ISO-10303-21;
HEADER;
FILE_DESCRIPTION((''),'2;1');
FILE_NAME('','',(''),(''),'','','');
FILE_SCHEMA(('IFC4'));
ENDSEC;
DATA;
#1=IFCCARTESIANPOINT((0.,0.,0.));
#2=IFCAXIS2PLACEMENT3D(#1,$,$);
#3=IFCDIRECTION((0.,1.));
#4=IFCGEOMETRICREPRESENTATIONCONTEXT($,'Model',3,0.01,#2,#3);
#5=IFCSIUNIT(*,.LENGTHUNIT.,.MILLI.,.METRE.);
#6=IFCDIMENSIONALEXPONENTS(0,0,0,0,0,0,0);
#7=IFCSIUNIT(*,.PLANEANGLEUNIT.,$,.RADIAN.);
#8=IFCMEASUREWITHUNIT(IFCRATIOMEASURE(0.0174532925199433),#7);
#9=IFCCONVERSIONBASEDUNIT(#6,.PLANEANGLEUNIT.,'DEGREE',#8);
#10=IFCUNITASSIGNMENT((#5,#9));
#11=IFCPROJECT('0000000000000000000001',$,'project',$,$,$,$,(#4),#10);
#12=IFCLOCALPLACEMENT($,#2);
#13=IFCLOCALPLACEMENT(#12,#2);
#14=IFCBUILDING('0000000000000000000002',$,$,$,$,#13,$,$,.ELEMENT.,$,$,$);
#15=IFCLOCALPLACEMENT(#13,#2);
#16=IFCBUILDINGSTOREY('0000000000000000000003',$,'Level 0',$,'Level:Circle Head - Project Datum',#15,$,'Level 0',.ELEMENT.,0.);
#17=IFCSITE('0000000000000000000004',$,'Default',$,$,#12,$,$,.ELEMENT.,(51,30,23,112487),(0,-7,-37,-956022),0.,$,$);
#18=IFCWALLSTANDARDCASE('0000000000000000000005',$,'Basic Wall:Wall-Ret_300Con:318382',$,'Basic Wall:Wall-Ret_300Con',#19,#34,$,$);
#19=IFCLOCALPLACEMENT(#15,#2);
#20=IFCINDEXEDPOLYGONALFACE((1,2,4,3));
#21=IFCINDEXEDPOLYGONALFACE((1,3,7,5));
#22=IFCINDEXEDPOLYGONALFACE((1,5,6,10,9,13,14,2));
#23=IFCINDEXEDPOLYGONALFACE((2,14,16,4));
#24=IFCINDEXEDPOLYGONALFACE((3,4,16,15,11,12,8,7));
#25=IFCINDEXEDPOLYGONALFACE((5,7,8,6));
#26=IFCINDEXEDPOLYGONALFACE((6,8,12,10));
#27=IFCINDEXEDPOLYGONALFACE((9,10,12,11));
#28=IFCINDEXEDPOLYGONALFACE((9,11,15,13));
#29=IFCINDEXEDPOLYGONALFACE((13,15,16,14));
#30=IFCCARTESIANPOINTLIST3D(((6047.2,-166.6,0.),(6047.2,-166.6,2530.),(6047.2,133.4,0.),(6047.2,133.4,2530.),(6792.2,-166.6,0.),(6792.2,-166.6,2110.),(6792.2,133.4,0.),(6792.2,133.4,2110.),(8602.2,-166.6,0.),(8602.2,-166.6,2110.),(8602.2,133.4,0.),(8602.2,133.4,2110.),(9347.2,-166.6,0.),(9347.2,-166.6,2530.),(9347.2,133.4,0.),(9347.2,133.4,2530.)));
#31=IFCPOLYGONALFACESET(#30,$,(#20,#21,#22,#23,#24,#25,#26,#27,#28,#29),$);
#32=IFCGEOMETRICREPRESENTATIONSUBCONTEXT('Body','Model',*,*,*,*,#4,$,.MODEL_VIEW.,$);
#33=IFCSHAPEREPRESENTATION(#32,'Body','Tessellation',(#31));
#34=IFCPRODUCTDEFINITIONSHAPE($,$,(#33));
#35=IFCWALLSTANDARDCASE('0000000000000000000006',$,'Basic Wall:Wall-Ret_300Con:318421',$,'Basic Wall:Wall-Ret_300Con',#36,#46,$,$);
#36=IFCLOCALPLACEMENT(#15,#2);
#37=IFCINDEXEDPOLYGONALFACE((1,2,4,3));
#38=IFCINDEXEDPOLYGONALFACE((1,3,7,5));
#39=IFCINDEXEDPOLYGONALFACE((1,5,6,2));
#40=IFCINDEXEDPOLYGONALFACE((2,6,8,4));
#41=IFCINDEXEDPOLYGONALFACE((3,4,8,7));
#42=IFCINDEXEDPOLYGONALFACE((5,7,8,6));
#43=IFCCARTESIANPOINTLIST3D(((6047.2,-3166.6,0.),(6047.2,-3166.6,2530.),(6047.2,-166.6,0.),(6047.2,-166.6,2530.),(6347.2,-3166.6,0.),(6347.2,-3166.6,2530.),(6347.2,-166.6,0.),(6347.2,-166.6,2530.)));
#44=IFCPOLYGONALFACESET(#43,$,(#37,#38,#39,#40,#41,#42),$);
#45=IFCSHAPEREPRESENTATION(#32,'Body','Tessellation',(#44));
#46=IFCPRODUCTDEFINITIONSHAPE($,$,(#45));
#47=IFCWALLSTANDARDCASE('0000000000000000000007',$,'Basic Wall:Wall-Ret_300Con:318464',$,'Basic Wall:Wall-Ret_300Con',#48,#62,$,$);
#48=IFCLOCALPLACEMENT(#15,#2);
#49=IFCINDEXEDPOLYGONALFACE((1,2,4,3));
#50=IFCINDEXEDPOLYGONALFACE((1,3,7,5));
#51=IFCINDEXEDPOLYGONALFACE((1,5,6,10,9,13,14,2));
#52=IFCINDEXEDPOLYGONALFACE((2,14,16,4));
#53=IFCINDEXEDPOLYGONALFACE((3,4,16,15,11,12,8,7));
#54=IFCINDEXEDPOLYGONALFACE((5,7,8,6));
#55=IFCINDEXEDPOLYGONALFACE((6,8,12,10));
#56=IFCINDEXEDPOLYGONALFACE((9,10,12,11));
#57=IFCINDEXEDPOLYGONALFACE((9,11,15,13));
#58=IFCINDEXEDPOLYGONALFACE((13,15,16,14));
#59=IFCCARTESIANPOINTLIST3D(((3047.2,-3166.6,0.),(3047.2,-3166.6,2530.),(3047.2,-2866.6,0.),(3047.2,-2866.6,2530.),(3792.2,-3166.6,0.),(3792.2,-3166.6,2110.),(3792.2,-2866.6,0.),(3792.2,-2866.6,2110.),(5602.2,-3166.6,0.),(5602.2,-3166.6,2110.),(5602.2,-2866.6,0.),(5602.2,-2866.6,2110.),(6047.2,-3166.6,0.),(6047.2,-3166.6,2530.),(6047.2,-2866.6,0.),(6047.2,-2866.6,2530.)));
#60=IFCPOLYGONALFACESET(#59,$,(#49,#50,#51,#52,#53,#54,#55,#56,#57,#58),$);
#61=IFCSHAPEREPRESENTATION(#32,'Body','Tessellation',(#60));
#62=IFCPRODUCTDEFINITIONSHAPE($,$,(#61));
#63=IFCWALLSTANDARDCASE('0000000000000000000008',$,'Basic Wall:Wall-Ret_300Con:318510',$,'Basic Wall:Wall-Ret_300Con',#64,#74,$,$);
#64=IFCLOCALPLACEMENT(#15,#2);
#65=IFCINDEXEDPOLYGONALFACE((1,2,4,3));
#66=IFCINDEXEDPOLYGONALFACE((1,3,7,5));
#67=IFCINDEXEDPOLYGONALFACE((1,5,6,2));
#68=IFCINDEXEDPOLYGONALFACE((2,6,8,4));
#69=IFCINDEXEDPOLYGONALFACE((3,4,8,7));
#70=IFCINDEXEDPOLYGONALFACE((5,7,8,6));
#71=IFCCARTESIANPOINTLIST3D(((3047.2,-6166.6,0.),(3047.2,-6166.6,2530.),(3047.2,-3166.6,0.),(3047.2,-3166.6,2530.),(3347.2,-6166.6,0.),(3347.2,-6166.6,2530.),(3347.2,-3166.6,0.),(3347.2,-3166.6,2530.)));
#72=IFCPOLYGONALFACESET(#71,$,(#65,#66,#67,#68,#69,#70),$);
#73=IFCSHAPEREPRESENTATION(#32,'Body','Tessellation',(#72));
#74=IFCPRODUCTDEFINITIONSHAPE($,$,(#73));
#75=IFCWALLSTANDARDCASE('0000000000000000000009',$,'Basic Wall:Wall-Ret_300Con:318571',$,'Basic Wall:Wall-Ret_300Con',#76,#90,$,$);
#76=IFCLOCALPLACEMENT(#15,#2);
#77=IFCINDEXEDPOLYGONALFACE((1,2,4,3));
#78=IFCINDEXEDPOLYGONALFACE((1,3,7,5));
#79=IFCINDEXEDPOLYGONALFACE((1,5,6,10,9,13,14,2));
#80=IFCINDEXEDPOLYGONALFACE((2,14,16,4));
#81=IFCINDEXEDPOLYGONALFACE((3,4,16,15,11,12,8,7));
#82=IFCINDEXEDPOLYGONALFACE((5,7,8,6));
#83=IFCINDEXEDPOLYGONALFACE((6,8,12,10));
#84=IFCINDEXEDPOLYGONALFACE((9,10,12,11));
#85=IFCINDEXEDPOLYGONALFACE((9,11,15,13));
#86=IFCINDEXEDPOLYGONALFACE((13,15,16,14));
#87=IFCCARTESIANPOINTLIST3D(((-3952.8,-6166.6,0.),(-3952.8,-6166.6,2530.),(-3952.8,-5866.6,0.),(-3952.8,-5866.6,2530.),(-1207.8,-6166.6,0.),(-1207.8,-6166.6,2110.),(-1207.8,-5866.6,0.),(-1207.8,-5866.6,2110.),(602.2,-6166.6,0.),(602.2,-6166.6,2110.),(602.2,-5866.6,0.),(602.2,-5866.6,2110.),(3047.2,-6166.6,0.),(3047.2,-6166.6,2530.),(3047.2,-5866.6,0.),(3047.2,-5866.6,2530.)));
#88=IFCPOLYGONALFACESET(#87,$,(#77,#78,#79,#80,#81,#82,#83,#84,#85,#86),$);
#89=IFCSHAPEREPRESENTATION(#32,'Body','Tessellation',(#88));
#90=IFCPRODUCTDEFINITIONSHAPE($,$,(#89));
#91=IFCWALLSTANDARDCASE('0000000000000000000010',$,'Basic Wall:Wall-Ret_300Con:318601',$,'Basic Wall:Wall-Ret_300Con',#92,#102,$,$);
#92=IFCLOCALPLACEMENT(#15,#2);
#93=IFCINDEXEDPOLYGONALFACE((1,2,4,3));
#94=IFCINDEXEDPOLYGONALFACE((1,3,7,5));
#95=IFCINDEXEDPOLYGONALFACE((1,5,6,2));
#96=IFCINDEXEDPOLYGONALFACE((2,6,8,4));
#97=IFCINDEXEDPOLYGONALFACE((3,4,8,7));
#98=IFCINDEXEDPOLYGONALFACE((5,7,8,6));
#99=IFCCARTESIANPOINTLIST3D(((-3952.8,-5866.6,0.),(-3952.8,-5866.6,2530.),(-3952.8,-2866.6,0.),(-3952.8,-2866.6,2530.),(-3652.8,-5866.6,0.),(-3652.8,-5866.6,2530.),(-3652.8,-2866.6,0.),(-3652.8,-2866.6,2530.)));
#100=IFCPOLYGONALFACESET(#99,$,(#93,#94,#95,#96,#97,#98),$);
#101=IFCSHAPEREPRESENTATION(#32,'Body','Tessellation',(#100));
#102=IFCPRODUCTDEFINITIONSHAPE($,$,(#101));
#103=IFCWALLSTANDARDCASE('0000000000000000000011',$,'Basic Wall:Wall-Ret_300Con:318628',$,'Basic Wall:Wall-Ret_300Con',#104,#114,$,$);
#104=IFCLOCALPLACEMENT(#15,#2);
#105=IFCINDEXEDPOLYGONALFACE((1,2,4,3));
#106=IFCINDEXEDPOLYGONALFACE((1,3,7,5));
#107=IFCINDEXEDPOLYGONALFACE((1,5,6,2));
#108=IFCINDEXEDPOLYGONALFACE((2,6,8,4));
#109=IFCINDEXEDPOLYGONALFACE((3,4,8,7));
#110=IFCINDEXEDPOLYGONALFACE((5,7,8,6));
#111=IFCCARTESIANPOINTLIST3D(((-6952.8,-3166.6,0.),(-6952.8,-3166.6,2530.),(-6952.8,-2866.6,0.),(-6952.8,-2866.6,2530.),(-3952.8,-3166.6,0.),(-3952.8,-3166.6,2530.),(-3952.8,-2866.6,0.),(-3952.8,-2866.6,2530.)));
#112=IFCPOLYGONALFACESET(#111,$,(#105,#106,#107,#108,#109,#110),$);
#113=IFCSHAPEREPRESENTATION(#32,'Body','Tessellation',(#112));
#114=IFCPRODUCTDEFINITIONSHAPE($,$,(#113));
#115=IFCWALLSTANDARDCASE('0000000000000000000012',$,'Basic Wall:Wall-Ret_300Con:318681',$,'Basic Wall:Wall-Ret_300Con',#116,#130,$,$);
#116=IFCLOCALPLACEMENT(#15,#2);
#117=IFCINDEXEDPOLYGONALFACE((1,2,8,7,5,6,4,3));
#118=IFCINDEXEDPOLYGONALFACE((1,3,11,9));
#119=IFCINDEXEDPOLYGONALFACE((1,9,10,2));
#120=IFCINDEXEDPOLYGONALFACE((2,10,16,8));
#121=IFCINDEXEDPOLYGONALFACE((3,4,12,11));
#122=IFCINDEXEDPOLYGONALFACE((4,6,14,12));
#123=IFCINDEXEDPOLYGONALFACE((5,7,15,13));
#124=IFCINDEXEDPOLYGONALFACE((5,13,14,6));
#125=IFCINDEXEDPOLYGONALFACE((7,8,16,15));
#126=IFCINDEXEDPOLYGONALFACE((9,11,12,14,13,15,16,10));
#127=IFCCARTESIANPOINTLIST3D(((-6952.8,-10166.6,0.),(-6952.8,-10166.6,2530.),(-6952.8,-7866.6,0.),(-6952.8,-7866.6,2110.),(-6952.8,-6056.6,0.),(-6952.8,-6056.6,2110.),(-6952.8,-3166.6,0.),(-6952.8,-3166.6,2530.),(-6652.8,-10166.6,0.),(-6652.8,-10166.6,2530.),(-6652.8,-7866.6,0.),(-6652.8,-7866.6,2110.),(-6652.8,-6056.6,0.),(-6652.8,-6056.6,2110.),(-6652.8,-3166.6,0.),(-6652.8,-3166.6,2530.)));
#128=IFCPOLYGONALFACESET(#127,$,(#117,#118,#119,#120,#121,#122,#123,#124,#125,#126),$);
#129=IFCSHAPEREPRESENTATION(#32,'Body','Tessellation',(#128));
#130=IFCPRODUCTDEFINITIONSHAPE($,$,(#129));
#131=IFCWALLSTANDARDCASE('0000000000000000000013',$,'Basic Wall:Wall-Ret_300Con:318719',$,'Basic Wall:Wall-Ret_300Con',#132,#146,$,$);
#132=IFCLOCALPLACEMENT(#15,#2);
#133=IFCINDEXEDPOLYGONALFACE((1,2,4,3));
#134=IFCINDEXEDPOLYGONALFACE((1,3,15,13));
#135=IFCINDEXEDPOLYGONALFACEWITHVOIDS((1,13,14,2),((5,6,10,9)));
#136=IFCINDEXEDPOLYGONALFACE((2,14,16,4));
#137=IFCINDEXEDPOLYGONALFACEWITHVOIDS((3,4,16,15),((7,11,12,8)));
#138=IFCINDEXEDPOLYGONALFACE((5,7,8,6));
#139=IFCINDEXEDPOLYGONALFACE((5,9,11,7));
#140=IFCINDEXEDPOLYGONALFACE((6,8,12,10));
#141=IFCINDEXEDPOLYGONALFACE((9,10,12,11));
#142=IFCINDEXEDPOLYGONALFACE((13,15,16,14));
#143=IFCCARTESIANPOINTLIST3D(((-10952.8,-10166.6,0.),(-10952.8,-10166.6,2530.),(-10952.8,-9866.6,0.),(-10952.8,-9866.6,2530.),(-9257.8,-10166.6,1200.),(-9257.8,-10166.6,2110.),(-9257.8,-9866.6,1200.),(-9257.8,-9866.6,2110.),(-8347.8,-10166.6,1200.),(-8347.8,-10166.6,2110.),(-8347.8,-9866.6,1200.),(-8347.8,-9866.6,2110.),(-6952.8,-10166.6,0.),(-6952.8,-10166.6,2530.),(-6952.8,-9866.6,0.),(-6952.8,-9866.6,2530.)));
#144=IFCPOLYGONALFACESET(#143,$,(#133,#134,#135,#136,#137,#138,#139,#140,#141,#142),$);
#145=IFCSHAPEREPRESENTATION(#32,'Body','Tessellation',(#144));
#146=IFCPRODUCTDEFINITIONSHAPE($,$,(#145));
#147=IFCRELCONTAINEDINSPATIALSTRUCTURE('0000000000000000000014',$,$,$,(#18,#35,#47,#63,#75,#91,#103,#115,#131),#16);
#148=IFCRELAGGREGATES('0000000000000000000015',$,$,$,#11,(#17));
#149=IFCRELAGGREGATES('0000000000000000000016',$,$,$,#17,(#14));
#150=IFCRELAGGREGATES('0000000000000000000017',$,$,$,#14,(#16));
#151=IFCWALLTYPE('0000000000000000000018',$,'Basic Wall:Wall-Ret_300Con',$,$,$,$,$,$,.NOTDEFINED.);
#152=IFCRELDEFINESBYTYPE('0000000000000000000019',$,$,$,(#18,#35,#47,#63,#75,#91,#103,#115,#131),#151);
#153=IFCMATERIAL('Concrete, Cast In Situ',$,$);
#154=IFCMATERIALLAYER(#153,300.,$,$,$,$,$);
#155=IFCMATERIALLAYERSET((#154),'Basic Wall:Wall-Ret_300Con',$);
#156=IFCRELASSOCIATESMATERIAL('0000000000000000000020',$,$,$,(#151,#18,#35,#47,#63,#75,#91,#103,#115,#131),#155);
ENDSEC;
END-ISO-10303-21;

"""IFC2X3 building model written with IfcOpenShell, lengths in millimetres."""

from ifc_helpers import new_model, entity, si_unit, converted_unit, direction, frame, frame_2d, origin, place, context, subcontext, project, spatial, polyline, rectangle, extrude, clip, bounded_halfspace, material, layer, layer_set, layer_usage, type_object, element, save


model = new_model("IFC2X3")

# Units and contexts
model_context = context("Model", 3, precision=0.01, world=origin(), true_north=direction((0.0, 1.0)))
body_context = subcontext(model_context, "Body", "Model", "MODEL_VIEW")
ifc_project = project(units=[si_unit("LENGTHUNIT", "METRE", prefix="MILLI"), converted_unit("PLANEANGLEUNIT", "DEGREE", entity("IfcRatioMeasure", 0.0174532925199433), si_unit("PLANEANGLEUNIT", "RADIAN"), dimensions=[0, 0, 0, 0, 0, 0, 0])], contexts=[model_context])

# Site, building, storey
site_placement = place(None, origin())
site = spatial("IfcSite", under=ifc_project, at=site_placement, Name="Default", CompositionType="ELEMENT", RefLatitude=(51, 30, 23, 112487), RefLongitude=(0, -7, -37, -956022), RefElevation=0.0)
building_placement = place(site_placement, origin())
building = spatial("IfcBuilding", under=site, at=building_placement, CompositionType="ELEMENT")
storey_placement = place(building_placement, origin())
storey = spatial("IfcBuildingStorey", under=building, at=storey_placement, Name="Level 0", ObjectType="Level:Circle Head - Project Datum", LongName="Level 0", CompositionType="ELEMENT", Elevation=0.0)

# Wall, opening
ifc_material_1 = material(Name="Concrete, Cast In Situ")
ifc_layer_1 = layer(ifc_material_1, 300.0)
ifc_layer_set_1 = layer_set([ifc_layer_1], Name="Basic Wall:Wall-Ret_300Con")
ifc_layer_usage_1 = layer_usage(ifc_layer_set_1, "AXIS2", "NEGATIVE", 150.0)
wall_type = type_object("IfcWallType", Name="Basic Wall:Wall-Ret_300Con", PredefinedType="NOTDEFINED", material=ifc_layer_set_1)
wall_1_placement = place(storey_placement, frame((9347.2, -16.6, 0.0), z_axis=(0.0, 0.0, 1.0), x_axis=(-1.0, 0.0, 0.0)))
wall_1 = element("IfcWallStandardCase", 1, at=wall_1_placement, inside=storey, type_object=wall_type, material=ifc_layer_usage_1, Name="Basic Wall:Wall-Ret_300Con:318382", ObjectType="Basic Wall:Wall-Ret_300Con", context=body_context, shape_type="Clipping", body=[
    clip(extrude(rectangle(XDim=3300.0, YDim=300.0, at=frame_2d((1650.0, 0.0), x_axis=(-1.0, 0.0))), origin(), (0.0, 0.0, 1.0), 2530.0), bounded_halfspace(frame((0.0, -150.0, 2530.0), z_axis=(0.0, 0.0, -1.0), x_axis=(-1.0, 0.0, 0.0)), True, frame((0.0, -150.0, 2530.0)), polyline([(0.0, 0.0), (300.0, 0.0), (3300.0, 0.0), (3300.0, 300.0), (3000.0, 300.0), (0.0, 300.0), (0.0, 0.0)]))),
])
opening_1_placement = place(wall_1_placement, frame((2555.0, 150.0, 0.0)))
element("IfcOpeningElement", 2, at=opening_1_placement, cuts=wall_1, ObjectType="Opening", context=body_context, shape_type="SweptSolid", body=[
    extrude(rectangle(XDim=2110.0, YDim=1810.0, at=frame_2d((1055.0, 905.0), x_axis=(-1.0, 0.0))), frame((0.0, 0.0, 0.0), z_axis=(0.0, -1.0, 0.0), x_axis=(0.0, 0.0, 1.0)), (0.0, 0.0, 1.0), 300.0),
])

# Wall
ifc_layer_usage_2 = layer_usage(ifc_layer_set_1, "AXIS2", "NEGATIVE", 150.0)
wall_2_placement = place(storey_placement, frame((6197.2, -166.6, 0.0), z_axis=(0.0, 0.0, 1.0), x_axis=(0.0, -1.0, 0.0)))
element("IfcWallStandardCase", 3, at=wall_2_placement, inside=storey, type_object=wall_type, material=ifc_layer_usage_2, Name="Basic Wall:Wall-Ret_300Con:318421", ObjectType="Basic Wall:Wall-Ret_300Con", context=body_context, shape_type="Clipping", body=[
    clip(extrude(rectangle(XDim=3000.0, YDim=300.0, at=frame_2d((1500.0, 0.0), x_axis=(-1.0, 0.0))), origin(), (0.0, 0.0, 1.0), 2530.0), bounded_halfspace(frame((0.0, -150.0, 2530.0), z_axis=(0.0, 0.0, -1.0), x_axis=(0.0, 1.0, 0.0)), True, frame((0.0, -150.0, 2530.0)), polyline([(0.0, 0.0), (2700.0, 0.0), (3000.0, 0.0), (3000.0, 300.0), (0.0, 300.0), (0.0, 0.0)]))),
])

# Wall, opening
ifc_layer_usage_3 = layer_usage(ifc_layer_set_1, "AXIS2", "NEGATIVE", 150.0)
wall_3_placement = place(storey_placement, frame((6047.2, -3016.6, 0.0), z_axis=(0.0, 0.0, 1.0), x_axis=(-1.0, 0.0, 0.0)))
wall_3 = element("IfcWallStandardCase", 4, at=wall_3_placement, inside=storey, type_object=wall_type, material=ifc_layer_usage_3, Name="Basic Wall:Wall-Ret_300Con:318464", ObjectType="Basic Wall:Wall-Ret_300Con", context=body_context, shape_type="Clipping", body=[
    clip(extrude(rectangle(XDim=3000.0, YDim=300.0, at=frame_2d((1500.0, 0.0), x_axis=(-1.0, 0.0))), origin(), (0.0, 0.0, 1.0), 2530.0), bounded_halfspace(frame((0.0, -150.0, 2530.0), z_axis=(0.0, 0.0, -1.0), x_axis=(-1.0, 0.0, 0.0)), True, frame((0.0, -150.0, 2530.0)), polyline([(0.0, 0.0), (3000.0, 0.0), (3000.0, 300.0), (2700.0, 300.0), (0.0, 300.0), (0.0, 0.0)]))),
])
opening_2_placement = place(wall_3_placement, frame((2255.0, 150.0, 0.0)))
element("IfcOpeningElement", 5, at=opening_2_placement, cuts=wall_3, ObjectType="Opening", context=body_context, shape_type="SweptSolid", body=[
    extrude(rectangle(XDim=2110.0, YDim=1810.0, at=frame_2d((1055.0, 905.0), x_axis=(-1.0, 0.0))), frame((0.0, 0.0, 0.0), z_axis=(0.0, -1.0, 0.0), x_axis=(0.0, 0.0, 1.0)), (0.0, 0.0, 1.0), 300.0),
])

# Wall
ifc_layer_usage_4 = layer_usage(ifc_layer_set_1, "AXIS2", "NEGATIVE", 150.0)
wall_4_placement = place(storey_placement, frame((3197.2, -3166.6, 0.0), z_axis=(0.0, 0.0, 1.0), x_axis=(0.0, -1.0, 0.0)))
element("IfcWallStandardCase", 6, at=wall_4_placement, inside=storey, type_object=wall_type, material=ifc_layer_usage_4, Name="Basic Wall:Wall-Ret_300Con:318510", ObjectType="Basic Wall:Wall-Ret_300Con", context=body_context, shape_type="Clipping", body=[
    clip(extrude(rectangle(XDim=3000.0, YDim=300.0, at=frame_2d((1500.0, 0.0), x_axis=(-1.0, 0.0))), origin(), (0.0, 0.0, 1.0), 2530.0), bounded_halfspace(frame((0.0, -150.0, 2530.0), z_axis=(0.0, 0.0, -1.0), x_axis=(0.0, 1.0, 0.0)), True, frame((0.0, -150.0, 2530.0)), polyline([(0.0, 0.0), (2700.0, 0.0), (3000.0, 0.0), (3000.0, 300.0), (0.0, 300.0), (0.0, 0.0)]))),
])

# Wall, opening
ifc_layer_usage_5 = layer_usage(ifc_layer_set_1, "AXIS2", "NEGATIVE", 150.0)
wall_5_placement = place(storey_placement, frame((3047.2, -6016.6, 0.0), z_axis=(0.0, 0.0, 1.0), x_axis=(-1.0, 0.0, 0.0)))
wall_5 = element("IfcWallStandardCase", 7, at=wall_5_placement, inside=storey, type_object=wall_type, material=ifc_layer_usage_5, Name="Basic Wall:Wall-Ret_300Con:318571", ObjectType="Basic Wall:Wall-Ret_300Con", context=body_context, shape_type="Clipping", body=[
    clip(extrude(rectangle(XDim=7000.0, YDim=300.0, at=frame_2d((3500.0, 0.0), x_axis=(-1.0, 0.0))), origin(), (0.0, 0.0, 1.0), 2530.0), bounded_halfspace(frame((0.0, -150.0, 2530.0), z_axis=(0.0, 0.0, -1.0), x_axis=(-1.0, 0.0, 0.0)), True, frame((0.0, -150.0, 2530.0)), polyline([(0.0, 0.0), (6700.0, 0.0), (7000.0, 0.0), (7000.0, 300.0), (0.0, 300.0), (0.0, 0.0)]))),
])
opening_3_placement = place(wall_5_placement, frame((4255.0, 150.0, 0.0)))
element("IfcOpeningElement", 8, at=opening_3_placement, cuts=wall_5, ObjectType="Opening", context=body_context, shape_type="SweptSolid", body=[
    extrude(rectangle(XDim=2110.0, YDim=1810.0, at=frame_2d((1055.0, 905.0), x_axis=(-1.0, 0.0))), frame((0.0, 0.0, 0.0), z_axis=(0.0, -1.0, 0.0), x_axis=(0.0, 0.0, 1.0)), (0.0, 0.0, 1.0), 300.0),
])

# Walls
ifc_layer_usage_6 = layer_usage(ifc_layer_set_1, "AXIS2", "NEGATIVE", 150.0)
wall_6_placement = place(storey_placement, frame((-3802.8, -5866.6, 0.0), z_axis=(0.0, 0.0, 1.0), x_axis=(0.0, 1.0, 0.0)))
element("IfcWallStandardCase", 9, at=wall_6_placement, inside=storey, type_object=wall_type, material=ifc_layer_usage_6, Name="Basic Wall:Wall-Ret_300Con:318601", ObjectType="Basic Wall:Wall-Ret_300Con", context=body_context, shape_type="Clipping", body=[
    clip(extrude(rectangle(XDim=3000.0, YDim=300.0, at=frame_2d((1500.0, 0.0), x_axis=(-1.0, 0.0))), origin(), (0.0, 0.0, 1.0), 2530.0), bounded_halfspace(frame((0.0, -150.0, 2530.0), z_axis=(0.0, 0.0, -1.0), x_axis=(0.0, -1.0, 0.0)), True, frame((0.0, -150.0, 2530.0)), polyline([(0.0, 0.0), (3000.0, 0.0), (3000.0, 300.0), (2700.0, 300.0), (0.0, 300.0), (0.0, 0.0)]))),
])
ifc_layer_usage_7 = layer_usage(ifc_layer_set_1, "AXIS2", "NEGATIVE", 150.0)
wall_7_placement = place(storey_placement, frame((-3952.8, -3016.6, 0.0), z_axis=(0.0, 0.0, 1.0), x_axis=(-1.0, 0.0, 0.0)))
element("IfcWallStandardCase", 10, at=wall_7_placement, inside=storey, type_object=wall_type, material=ifc_layer_usage_7, Name="Basic Wall:Wall-Ret_300Con:318628", ObjectType="Basic Wall:Wall-Ret_300Con", context=body_context, shape_type="Clipping", body=[
    clip(extrude(rectangle(XDim=3000.0, YDim=300.0, at=frame_2d((1500.0, 0.0), x_axis=(-1.0, 0.0))), origin(), (0.0, 0.0, 1.0), 2530.0), bounded_halfspace(frame((0.0, -150.0, 2530.0), z_axis=(0.0, 0.0, -1.0), x_axis=(-1.0, 0.0, 0.0)), True, frame((0.0, -150.0, 2530.0)), polyline([(0.0, 0.0), (3000.0, 0.0), (3000.0, 300.0), (2700.0, 300.0), (0.0, 300.0), (0.0, 0.0)]))),
])

# Walls, openings
ifc_layer_usage_8 = layer_usage(ifc_layer_set_1, "AXIS2", "NEGATIVE", 150.0)
wall_8_placement = place(storey_placement, frame((-6802.8, -3166.6, 0.0), z_axis=(0.0, 0.0, 1.0), x_axis=(0.0, -1.0, 0.0)))
wall_8 = element("IfcWallStandardCase", 11, at=wall_8_placement, inside=storey, type_object=wall_type, material=ifc_layer_usage_8, Name="Basic Wall:Wall-Ret_300Con:318681", ObjectType="Basic Wall:Wall-Ret_300Con", context=body_context, shape_type="Clipping", body=[
    clip(extrude(rectangle(XDim=7000.0, YDim=300.0, at=frame_2d((3500.0, 0.0), x_axis=(-1.0, 0.0))), origin(), (0.0, 0.0, 1.0), 2530.0), bounded_halfspace(frame((0.0, -150.0, 2530.0), z_axis=(0.0, 0.0, -1.0), x_axis=(0.0, 1.0, 0.0)), True, frame((0.0, -150.0, 2530.0)), polyline([(0.0, 0.0), (6700.0, 0.0), (7000.0, 0.0), (7000.0, 300.0), (0.0, 300.0), (0.0, 0.0)]))),
])
opening_4_placement = place(wall_8_placement, frame((4700.0, 150.0, 0.0)))
element("IfcOpeningElement", 12, at=opening_4_placement, cuts=wall_8, ObjectType="Opening", context=body_context, shape_type="SweptSolid", body=[
    extrude(rectangle(XDim=2110.0, YDim=1810.0, at=frame_2d((1055.0, 905.0), x_axis=(-1.0, 0.0))), frame((0.0, 0.0, 0.0), z_axis=(0.0, -1.0, 0.0), x_axis=(0.0, 0.0, 1.0)), (0.0, 0.0, 1.0), 300.0),
])
ifc_layer_usage_9 = layer_usage(ifc_layer_set_1, "AXIS2", "NEGATIVE", 150.0)
wall_9_placement = place(storey_placement, frame((-6952.8, -10016.6, 0.0), z_axis=(0.0, 0.0, 1.0), x_axis=(-1.0, 0.0, 0.0)))
wall_9 = element("IfcWallStandardCase", 13, at=wall_9_placement, inside=storey, type_object=wall_type, material=ifc_layer_usage_9, Name="Basic Wall:Wall-Ret_300Con:318719", ObjectType="Basic Wall:Wall-Ret_300Con", context=body_context, shape_type="Clipping", body=[
    clip(extrude(rectangle(XDim=4000.0, YDim=300.0, at=frame_2d((2000.0, 0.0), x_axis=(-1.0, 0.0))), origin(), (0.0, 0.0, 1.0), 2530.0), bounded_halfspace(frame((0.0, -150.0, 2530.0), z_axis=(0.0, 0.0, -1.0), x_axis=(-1.0, 0.0, 0.0)), True, frame((0.0, -150.0, 2530.0)), polyline([(0.0, 0.0), (3700.0, 0.0), (4000.0, 0.0), (4000.0, 300.0), (0.0, 300.0), (0.0, 0.0)]))),
])
opening_5_placement = place(wall_9_placement, frame((2305.0, 150.0, 1200.0)))
element("IfcOpeningElement", 14, at=opening_5_placement, cuts=wall_9, ObjectType="Opening", context=body_context, shape_type="SweptSolid", body=[
    extrude(rectangle(XDim=910.0, YDim=910.0, at=frame_2d((455.0, 455.0), x_axis=(-1.0, 0.0))), frame((0.0, 0.0, 0.0), z_axis=(0.0, -1.0, 0.0), x_axis=(0.0, 0.0, 1.0)), (0.0, 0.0, 1.0), 300.0),
])

save(model, "model.ifc")
